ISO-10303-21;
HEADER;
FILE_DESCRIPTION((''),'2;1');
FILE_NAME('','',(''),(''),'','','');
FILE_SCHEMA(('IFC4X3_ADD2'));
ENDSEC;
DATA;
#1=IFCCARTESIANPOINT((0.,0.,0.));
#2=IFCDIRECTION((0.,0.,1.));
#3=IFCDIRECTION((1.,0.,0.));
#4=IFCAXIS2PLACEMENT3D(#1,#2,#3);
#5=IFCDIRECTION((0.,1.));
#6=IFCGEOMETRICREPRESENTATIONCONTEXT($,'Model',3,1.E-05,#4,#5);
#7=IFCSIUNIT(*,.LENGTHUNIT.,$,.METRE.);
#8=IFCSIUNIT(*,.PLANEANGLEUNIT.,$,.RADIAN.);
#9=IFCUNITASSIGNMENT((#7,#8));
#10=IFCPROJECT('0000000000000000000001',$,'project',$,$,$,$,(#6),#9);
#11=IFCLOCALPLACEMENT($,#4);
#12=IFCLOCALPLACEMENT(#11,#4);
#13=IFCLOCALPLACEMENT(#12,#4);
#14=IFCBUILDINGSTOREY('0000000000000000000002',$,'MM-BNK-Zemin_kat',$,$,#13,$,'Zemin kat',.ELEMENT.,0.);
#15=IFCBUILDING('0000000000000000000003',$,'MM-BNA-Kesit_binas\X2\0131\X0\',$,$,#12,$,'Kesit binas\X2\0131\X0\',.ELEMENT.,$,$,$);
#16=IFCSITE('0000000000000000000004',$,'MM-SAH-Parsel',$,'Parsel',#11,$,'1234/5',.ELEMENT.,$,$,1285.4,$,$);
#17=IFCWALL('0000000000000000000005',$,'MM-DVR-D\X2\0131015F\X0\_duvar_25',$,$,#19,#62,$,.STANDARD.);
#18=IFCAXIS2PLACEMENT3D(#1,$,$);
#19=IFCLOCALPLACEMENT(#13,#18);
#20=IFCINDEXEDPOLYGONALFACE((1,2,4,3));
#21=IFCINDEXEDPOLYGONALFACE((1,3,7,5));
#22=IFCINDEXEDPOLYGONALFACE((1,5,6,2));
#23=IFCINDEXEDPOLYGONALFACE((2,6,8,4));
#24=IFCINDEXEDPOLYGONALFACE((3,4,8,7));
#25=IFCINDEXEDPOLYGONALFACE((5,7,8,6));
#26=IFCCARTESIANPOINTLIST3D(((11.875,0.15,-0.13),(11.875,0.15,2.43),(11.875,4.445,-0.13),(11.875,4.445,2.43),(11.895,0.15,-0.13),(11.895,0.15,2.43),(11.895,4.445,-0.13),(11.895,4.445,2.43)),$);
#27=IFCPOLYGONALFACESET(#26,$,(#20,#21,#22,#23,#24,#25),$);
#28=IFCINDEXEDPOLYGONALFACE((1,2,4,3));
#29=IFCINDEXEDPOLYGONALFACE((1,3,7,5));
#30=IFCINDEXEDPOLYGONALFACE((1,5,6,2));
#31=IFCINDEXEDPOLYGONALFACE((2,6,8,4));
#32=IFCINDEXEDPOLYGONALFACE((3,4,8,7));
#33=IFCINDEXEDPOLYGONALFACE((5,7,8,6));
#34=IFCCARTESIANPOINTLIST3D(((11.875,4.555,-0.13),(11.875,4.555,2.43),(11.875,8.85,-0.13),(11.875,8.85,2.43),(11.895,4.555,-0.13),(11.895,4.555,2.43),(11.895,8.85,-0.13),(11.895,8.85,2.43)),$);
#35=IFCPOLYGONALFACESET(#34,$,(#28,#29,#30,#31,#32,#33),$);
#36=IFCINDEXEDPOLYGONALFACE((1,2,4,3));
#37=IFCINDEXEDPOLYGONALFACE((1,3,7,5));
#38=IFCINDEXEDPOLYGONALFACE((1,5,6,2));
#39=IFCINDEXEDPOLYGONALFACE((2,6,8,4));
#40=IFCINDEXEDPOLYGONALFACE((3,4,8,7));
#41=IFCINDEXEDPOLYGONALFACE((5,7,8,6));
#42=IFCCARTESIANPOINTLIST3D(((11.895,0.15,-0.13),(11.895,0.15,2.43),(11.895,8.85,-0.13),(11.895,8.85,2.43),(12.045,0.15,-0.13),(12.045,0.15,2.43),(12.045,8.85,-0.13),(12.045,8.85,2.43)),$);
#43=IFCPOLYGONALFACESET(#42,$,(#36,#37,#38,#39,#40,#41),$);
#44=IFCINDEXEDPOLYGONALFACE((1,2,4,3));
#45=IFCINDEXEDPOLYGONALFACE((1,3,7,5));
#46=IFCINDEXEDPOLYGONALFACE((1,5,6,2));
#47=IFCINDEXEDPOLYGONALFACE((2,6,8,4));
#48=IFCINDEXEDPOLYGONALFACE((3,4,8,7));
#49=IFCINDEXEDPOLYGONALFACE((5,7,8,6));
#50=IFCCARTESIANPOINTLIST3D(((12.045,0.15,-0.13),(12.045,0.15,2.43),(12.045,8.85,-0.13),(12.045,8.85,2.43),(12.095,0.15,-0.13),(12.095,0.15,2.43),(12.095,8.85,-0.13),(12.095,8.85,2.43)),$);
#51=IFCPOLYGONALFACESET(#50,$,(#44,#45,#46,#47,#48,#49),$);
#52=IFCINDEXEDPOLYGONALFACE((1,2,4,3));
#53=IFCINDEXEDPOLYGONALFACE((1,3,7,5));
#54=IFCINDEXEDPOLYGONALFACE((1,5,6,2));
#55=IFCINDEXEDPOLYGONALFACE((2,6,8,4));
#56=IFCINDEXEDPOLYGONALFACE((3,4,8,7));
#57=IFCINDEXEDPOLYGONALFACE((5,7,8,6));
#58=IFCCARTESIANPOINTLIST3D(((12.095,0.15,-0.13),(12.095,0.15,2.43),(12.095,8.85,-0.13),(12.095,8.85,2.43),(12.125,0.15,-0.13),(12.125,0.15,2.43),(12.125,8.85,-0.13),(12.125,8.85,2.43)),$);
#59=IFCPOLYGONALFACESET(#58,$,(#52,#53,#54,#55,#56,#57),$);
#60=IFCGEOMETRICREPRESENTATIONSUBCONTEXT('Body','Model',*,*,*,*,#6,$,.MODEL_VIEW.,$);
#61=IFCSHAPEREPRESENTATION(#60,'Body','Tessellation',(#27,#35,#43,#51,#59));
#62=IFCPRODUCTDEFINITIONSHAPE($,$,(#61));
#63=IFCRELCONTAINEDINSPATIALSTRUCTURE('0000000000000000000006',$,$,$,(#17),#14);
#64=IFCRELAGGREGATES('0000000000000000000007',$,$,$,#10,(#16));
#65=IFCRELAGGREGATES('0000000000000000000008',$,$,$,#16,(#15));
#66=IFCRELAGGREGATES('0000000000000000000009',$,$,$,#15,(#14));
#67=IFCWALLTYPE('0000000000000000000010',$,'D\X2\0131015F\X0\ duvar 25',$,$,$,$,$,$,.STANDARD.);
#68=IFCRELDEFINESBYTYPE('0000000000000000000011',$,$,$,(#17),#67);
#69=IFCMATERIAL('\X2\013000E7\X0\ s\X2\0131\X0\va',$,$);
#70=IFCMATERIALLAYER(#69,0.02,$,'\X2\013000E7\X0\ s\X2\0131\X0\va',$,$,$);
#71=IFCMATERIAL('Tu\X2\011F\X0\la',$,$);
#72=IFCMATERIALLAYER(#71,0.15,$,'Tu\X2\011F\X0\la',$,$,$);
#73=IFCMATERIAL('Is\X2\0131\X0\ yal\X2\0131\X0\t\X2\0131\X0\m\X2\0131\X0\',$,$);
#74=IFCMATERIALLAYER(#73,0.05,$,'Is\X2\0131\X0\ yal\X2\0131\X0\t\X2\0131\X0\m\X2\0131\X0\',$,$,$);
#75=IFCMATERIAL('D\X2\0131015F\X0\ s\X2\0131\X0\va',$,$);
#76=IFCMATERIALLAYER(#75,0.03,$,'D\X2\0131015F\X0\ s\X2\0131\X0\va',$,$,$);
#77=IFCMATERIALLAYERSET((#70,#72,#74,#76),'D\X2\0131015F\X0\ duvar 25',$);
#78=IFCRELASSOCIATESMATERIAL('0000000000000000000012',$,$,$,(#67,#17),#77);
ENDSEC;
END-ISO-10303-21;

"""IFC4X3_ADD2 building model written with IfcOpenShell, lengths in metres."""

from ifc_helpers import new_model, si_unit, direction, frame, origin_with_axes, place, context, subcontext, project, spatial, polyline, outline, extrude, material, layer, layer_set, type_object, element, save


model = new_model("IFC4X3_ADD2")

# Units and contexts
model_context = context("Model", 3, precision=1e-05, world=origin_with_axes(), true_north=direction((0.0, 1.0)))
body_context = subcontext(model_context, "Body", "Model", "MODEL_VIEW")
ifc_project = project(units=[si_unit("LENGTHUNIT", "METRE"), si_unit("PLANEANGLEUNIT", "RADIAN")], contexts=[model_context])

# Site, building, storey
site_placement = place(None, origin_with_axes())
site = spatial("IfcSite", under=ifc_project, at=site_placement, Name="MM-SAH-Parsel", ObjectType="Parsel", LongName="1234/5", CompositionType="ELEMENT", RefElevation=1285.4)
building_placement = place(site_placement, origin_with_axes())
building = spatial("IfcBuilding", under=site, at=building_placement, Name="MM-BNA-Kesit_binası", LongName="Kesit binası", CompositionType="ELEMENT")
storey_placement = place(building_placement, origin_with_axes())
storey = spatial("IfcBuildingStorey", under=building, at=storey_placement, Name="MM-BNK-Zemin_kat", LongName="Zemin kat", CompositionType="ELEMENT", Elevation=0.0)

# Shared definitions
ifc_material_1 = material(Name="İç sıva")
ifc_layer_1 = layer(ifc_material_1, 0.02, Name="İç sıva")
ifc_material_2 = material(Name="Tuğla")
ifc_layer_2 = layer(ifc_material_2, 0.15, Name="Tuğla")
ifc_material_3 = material(Name="Isı yalıtımı")
ifc_layer_3 = layer(ifc_material_3, 0.05, Name="Isı yalıtımı")
ifc_material_4 = material(Name="Dış sıva")
ifc_layer_4 = layer(ifc_material_4, 0.03, Name="Dış sıva")
ifc_layer_set_1 = layer_set([ifc_layer_1, ifc_layer_2, ifc_layer_3, ifc_layer_4], Name="Dış duvar 25")
wall_type_1 = type_object("IfcWallType", Name="Dış duvar 25", PredefinedType="STANDARD", material=ifc_layer_set_1)

# Wall
wall_1_placement = place(storey_placement, origin_with_axes())
element("IfcWall", 1, at=wall_1_placement, inside=storey, type_object=wall_type_1, material=ifc_layer_set_1, Name="MM-DVR-Dış_duvar_25", PredefinedType="STANDARD", context=body_context, shape_type="SweptSolid", body=[
    extrude(outline(polyline([(11.895, 0.15), (11.895, 4.445), (11.875, 4.445), (11.875, 0.15), (11.895, 0.15)])), frame((0.0, 0.0, -0.13)), (0.0, 0.0, 1.0), 2.56),
    extrude(outline(polyline([(11.895, 4.555), (11.895, 8.85), (11.875, 8.85), (11.875, 4.555), (11.895, 4.555)])), frame((0.0, 0.0, -0.13)), (0.0, 0.0, 1.0), 2.56),
    extrude(outline(polyline([(12.045, 0.15), (12.045, 8.85), (11.895, 8.85), (11.895, 0.15), (12.045, 0.15)])), frame((0.0, 0.0, -0.13)), (0.0, 0.0, 1.0), 2.56),
    extrude(outline(polyline([(12.095, 0.15), (12.095, 8.85), (12.045, 8.85), (12.045, 0.15), (12.095, 0.15)])), frame((0.0, 0.0, -0.13)), (0.0, 0.0, 1.0), 2.56),
    extrude(outline(polyline([(12.125, 0.15), (12.125, 8.85), (12.095, 8.85), (12.095, 0.15), (12.125, 0.15)])), frame((0.0, 0.0, -0.13)), (0.0, 0.0, 1.0), 2.56),
])

save(model, "model.ifc")
